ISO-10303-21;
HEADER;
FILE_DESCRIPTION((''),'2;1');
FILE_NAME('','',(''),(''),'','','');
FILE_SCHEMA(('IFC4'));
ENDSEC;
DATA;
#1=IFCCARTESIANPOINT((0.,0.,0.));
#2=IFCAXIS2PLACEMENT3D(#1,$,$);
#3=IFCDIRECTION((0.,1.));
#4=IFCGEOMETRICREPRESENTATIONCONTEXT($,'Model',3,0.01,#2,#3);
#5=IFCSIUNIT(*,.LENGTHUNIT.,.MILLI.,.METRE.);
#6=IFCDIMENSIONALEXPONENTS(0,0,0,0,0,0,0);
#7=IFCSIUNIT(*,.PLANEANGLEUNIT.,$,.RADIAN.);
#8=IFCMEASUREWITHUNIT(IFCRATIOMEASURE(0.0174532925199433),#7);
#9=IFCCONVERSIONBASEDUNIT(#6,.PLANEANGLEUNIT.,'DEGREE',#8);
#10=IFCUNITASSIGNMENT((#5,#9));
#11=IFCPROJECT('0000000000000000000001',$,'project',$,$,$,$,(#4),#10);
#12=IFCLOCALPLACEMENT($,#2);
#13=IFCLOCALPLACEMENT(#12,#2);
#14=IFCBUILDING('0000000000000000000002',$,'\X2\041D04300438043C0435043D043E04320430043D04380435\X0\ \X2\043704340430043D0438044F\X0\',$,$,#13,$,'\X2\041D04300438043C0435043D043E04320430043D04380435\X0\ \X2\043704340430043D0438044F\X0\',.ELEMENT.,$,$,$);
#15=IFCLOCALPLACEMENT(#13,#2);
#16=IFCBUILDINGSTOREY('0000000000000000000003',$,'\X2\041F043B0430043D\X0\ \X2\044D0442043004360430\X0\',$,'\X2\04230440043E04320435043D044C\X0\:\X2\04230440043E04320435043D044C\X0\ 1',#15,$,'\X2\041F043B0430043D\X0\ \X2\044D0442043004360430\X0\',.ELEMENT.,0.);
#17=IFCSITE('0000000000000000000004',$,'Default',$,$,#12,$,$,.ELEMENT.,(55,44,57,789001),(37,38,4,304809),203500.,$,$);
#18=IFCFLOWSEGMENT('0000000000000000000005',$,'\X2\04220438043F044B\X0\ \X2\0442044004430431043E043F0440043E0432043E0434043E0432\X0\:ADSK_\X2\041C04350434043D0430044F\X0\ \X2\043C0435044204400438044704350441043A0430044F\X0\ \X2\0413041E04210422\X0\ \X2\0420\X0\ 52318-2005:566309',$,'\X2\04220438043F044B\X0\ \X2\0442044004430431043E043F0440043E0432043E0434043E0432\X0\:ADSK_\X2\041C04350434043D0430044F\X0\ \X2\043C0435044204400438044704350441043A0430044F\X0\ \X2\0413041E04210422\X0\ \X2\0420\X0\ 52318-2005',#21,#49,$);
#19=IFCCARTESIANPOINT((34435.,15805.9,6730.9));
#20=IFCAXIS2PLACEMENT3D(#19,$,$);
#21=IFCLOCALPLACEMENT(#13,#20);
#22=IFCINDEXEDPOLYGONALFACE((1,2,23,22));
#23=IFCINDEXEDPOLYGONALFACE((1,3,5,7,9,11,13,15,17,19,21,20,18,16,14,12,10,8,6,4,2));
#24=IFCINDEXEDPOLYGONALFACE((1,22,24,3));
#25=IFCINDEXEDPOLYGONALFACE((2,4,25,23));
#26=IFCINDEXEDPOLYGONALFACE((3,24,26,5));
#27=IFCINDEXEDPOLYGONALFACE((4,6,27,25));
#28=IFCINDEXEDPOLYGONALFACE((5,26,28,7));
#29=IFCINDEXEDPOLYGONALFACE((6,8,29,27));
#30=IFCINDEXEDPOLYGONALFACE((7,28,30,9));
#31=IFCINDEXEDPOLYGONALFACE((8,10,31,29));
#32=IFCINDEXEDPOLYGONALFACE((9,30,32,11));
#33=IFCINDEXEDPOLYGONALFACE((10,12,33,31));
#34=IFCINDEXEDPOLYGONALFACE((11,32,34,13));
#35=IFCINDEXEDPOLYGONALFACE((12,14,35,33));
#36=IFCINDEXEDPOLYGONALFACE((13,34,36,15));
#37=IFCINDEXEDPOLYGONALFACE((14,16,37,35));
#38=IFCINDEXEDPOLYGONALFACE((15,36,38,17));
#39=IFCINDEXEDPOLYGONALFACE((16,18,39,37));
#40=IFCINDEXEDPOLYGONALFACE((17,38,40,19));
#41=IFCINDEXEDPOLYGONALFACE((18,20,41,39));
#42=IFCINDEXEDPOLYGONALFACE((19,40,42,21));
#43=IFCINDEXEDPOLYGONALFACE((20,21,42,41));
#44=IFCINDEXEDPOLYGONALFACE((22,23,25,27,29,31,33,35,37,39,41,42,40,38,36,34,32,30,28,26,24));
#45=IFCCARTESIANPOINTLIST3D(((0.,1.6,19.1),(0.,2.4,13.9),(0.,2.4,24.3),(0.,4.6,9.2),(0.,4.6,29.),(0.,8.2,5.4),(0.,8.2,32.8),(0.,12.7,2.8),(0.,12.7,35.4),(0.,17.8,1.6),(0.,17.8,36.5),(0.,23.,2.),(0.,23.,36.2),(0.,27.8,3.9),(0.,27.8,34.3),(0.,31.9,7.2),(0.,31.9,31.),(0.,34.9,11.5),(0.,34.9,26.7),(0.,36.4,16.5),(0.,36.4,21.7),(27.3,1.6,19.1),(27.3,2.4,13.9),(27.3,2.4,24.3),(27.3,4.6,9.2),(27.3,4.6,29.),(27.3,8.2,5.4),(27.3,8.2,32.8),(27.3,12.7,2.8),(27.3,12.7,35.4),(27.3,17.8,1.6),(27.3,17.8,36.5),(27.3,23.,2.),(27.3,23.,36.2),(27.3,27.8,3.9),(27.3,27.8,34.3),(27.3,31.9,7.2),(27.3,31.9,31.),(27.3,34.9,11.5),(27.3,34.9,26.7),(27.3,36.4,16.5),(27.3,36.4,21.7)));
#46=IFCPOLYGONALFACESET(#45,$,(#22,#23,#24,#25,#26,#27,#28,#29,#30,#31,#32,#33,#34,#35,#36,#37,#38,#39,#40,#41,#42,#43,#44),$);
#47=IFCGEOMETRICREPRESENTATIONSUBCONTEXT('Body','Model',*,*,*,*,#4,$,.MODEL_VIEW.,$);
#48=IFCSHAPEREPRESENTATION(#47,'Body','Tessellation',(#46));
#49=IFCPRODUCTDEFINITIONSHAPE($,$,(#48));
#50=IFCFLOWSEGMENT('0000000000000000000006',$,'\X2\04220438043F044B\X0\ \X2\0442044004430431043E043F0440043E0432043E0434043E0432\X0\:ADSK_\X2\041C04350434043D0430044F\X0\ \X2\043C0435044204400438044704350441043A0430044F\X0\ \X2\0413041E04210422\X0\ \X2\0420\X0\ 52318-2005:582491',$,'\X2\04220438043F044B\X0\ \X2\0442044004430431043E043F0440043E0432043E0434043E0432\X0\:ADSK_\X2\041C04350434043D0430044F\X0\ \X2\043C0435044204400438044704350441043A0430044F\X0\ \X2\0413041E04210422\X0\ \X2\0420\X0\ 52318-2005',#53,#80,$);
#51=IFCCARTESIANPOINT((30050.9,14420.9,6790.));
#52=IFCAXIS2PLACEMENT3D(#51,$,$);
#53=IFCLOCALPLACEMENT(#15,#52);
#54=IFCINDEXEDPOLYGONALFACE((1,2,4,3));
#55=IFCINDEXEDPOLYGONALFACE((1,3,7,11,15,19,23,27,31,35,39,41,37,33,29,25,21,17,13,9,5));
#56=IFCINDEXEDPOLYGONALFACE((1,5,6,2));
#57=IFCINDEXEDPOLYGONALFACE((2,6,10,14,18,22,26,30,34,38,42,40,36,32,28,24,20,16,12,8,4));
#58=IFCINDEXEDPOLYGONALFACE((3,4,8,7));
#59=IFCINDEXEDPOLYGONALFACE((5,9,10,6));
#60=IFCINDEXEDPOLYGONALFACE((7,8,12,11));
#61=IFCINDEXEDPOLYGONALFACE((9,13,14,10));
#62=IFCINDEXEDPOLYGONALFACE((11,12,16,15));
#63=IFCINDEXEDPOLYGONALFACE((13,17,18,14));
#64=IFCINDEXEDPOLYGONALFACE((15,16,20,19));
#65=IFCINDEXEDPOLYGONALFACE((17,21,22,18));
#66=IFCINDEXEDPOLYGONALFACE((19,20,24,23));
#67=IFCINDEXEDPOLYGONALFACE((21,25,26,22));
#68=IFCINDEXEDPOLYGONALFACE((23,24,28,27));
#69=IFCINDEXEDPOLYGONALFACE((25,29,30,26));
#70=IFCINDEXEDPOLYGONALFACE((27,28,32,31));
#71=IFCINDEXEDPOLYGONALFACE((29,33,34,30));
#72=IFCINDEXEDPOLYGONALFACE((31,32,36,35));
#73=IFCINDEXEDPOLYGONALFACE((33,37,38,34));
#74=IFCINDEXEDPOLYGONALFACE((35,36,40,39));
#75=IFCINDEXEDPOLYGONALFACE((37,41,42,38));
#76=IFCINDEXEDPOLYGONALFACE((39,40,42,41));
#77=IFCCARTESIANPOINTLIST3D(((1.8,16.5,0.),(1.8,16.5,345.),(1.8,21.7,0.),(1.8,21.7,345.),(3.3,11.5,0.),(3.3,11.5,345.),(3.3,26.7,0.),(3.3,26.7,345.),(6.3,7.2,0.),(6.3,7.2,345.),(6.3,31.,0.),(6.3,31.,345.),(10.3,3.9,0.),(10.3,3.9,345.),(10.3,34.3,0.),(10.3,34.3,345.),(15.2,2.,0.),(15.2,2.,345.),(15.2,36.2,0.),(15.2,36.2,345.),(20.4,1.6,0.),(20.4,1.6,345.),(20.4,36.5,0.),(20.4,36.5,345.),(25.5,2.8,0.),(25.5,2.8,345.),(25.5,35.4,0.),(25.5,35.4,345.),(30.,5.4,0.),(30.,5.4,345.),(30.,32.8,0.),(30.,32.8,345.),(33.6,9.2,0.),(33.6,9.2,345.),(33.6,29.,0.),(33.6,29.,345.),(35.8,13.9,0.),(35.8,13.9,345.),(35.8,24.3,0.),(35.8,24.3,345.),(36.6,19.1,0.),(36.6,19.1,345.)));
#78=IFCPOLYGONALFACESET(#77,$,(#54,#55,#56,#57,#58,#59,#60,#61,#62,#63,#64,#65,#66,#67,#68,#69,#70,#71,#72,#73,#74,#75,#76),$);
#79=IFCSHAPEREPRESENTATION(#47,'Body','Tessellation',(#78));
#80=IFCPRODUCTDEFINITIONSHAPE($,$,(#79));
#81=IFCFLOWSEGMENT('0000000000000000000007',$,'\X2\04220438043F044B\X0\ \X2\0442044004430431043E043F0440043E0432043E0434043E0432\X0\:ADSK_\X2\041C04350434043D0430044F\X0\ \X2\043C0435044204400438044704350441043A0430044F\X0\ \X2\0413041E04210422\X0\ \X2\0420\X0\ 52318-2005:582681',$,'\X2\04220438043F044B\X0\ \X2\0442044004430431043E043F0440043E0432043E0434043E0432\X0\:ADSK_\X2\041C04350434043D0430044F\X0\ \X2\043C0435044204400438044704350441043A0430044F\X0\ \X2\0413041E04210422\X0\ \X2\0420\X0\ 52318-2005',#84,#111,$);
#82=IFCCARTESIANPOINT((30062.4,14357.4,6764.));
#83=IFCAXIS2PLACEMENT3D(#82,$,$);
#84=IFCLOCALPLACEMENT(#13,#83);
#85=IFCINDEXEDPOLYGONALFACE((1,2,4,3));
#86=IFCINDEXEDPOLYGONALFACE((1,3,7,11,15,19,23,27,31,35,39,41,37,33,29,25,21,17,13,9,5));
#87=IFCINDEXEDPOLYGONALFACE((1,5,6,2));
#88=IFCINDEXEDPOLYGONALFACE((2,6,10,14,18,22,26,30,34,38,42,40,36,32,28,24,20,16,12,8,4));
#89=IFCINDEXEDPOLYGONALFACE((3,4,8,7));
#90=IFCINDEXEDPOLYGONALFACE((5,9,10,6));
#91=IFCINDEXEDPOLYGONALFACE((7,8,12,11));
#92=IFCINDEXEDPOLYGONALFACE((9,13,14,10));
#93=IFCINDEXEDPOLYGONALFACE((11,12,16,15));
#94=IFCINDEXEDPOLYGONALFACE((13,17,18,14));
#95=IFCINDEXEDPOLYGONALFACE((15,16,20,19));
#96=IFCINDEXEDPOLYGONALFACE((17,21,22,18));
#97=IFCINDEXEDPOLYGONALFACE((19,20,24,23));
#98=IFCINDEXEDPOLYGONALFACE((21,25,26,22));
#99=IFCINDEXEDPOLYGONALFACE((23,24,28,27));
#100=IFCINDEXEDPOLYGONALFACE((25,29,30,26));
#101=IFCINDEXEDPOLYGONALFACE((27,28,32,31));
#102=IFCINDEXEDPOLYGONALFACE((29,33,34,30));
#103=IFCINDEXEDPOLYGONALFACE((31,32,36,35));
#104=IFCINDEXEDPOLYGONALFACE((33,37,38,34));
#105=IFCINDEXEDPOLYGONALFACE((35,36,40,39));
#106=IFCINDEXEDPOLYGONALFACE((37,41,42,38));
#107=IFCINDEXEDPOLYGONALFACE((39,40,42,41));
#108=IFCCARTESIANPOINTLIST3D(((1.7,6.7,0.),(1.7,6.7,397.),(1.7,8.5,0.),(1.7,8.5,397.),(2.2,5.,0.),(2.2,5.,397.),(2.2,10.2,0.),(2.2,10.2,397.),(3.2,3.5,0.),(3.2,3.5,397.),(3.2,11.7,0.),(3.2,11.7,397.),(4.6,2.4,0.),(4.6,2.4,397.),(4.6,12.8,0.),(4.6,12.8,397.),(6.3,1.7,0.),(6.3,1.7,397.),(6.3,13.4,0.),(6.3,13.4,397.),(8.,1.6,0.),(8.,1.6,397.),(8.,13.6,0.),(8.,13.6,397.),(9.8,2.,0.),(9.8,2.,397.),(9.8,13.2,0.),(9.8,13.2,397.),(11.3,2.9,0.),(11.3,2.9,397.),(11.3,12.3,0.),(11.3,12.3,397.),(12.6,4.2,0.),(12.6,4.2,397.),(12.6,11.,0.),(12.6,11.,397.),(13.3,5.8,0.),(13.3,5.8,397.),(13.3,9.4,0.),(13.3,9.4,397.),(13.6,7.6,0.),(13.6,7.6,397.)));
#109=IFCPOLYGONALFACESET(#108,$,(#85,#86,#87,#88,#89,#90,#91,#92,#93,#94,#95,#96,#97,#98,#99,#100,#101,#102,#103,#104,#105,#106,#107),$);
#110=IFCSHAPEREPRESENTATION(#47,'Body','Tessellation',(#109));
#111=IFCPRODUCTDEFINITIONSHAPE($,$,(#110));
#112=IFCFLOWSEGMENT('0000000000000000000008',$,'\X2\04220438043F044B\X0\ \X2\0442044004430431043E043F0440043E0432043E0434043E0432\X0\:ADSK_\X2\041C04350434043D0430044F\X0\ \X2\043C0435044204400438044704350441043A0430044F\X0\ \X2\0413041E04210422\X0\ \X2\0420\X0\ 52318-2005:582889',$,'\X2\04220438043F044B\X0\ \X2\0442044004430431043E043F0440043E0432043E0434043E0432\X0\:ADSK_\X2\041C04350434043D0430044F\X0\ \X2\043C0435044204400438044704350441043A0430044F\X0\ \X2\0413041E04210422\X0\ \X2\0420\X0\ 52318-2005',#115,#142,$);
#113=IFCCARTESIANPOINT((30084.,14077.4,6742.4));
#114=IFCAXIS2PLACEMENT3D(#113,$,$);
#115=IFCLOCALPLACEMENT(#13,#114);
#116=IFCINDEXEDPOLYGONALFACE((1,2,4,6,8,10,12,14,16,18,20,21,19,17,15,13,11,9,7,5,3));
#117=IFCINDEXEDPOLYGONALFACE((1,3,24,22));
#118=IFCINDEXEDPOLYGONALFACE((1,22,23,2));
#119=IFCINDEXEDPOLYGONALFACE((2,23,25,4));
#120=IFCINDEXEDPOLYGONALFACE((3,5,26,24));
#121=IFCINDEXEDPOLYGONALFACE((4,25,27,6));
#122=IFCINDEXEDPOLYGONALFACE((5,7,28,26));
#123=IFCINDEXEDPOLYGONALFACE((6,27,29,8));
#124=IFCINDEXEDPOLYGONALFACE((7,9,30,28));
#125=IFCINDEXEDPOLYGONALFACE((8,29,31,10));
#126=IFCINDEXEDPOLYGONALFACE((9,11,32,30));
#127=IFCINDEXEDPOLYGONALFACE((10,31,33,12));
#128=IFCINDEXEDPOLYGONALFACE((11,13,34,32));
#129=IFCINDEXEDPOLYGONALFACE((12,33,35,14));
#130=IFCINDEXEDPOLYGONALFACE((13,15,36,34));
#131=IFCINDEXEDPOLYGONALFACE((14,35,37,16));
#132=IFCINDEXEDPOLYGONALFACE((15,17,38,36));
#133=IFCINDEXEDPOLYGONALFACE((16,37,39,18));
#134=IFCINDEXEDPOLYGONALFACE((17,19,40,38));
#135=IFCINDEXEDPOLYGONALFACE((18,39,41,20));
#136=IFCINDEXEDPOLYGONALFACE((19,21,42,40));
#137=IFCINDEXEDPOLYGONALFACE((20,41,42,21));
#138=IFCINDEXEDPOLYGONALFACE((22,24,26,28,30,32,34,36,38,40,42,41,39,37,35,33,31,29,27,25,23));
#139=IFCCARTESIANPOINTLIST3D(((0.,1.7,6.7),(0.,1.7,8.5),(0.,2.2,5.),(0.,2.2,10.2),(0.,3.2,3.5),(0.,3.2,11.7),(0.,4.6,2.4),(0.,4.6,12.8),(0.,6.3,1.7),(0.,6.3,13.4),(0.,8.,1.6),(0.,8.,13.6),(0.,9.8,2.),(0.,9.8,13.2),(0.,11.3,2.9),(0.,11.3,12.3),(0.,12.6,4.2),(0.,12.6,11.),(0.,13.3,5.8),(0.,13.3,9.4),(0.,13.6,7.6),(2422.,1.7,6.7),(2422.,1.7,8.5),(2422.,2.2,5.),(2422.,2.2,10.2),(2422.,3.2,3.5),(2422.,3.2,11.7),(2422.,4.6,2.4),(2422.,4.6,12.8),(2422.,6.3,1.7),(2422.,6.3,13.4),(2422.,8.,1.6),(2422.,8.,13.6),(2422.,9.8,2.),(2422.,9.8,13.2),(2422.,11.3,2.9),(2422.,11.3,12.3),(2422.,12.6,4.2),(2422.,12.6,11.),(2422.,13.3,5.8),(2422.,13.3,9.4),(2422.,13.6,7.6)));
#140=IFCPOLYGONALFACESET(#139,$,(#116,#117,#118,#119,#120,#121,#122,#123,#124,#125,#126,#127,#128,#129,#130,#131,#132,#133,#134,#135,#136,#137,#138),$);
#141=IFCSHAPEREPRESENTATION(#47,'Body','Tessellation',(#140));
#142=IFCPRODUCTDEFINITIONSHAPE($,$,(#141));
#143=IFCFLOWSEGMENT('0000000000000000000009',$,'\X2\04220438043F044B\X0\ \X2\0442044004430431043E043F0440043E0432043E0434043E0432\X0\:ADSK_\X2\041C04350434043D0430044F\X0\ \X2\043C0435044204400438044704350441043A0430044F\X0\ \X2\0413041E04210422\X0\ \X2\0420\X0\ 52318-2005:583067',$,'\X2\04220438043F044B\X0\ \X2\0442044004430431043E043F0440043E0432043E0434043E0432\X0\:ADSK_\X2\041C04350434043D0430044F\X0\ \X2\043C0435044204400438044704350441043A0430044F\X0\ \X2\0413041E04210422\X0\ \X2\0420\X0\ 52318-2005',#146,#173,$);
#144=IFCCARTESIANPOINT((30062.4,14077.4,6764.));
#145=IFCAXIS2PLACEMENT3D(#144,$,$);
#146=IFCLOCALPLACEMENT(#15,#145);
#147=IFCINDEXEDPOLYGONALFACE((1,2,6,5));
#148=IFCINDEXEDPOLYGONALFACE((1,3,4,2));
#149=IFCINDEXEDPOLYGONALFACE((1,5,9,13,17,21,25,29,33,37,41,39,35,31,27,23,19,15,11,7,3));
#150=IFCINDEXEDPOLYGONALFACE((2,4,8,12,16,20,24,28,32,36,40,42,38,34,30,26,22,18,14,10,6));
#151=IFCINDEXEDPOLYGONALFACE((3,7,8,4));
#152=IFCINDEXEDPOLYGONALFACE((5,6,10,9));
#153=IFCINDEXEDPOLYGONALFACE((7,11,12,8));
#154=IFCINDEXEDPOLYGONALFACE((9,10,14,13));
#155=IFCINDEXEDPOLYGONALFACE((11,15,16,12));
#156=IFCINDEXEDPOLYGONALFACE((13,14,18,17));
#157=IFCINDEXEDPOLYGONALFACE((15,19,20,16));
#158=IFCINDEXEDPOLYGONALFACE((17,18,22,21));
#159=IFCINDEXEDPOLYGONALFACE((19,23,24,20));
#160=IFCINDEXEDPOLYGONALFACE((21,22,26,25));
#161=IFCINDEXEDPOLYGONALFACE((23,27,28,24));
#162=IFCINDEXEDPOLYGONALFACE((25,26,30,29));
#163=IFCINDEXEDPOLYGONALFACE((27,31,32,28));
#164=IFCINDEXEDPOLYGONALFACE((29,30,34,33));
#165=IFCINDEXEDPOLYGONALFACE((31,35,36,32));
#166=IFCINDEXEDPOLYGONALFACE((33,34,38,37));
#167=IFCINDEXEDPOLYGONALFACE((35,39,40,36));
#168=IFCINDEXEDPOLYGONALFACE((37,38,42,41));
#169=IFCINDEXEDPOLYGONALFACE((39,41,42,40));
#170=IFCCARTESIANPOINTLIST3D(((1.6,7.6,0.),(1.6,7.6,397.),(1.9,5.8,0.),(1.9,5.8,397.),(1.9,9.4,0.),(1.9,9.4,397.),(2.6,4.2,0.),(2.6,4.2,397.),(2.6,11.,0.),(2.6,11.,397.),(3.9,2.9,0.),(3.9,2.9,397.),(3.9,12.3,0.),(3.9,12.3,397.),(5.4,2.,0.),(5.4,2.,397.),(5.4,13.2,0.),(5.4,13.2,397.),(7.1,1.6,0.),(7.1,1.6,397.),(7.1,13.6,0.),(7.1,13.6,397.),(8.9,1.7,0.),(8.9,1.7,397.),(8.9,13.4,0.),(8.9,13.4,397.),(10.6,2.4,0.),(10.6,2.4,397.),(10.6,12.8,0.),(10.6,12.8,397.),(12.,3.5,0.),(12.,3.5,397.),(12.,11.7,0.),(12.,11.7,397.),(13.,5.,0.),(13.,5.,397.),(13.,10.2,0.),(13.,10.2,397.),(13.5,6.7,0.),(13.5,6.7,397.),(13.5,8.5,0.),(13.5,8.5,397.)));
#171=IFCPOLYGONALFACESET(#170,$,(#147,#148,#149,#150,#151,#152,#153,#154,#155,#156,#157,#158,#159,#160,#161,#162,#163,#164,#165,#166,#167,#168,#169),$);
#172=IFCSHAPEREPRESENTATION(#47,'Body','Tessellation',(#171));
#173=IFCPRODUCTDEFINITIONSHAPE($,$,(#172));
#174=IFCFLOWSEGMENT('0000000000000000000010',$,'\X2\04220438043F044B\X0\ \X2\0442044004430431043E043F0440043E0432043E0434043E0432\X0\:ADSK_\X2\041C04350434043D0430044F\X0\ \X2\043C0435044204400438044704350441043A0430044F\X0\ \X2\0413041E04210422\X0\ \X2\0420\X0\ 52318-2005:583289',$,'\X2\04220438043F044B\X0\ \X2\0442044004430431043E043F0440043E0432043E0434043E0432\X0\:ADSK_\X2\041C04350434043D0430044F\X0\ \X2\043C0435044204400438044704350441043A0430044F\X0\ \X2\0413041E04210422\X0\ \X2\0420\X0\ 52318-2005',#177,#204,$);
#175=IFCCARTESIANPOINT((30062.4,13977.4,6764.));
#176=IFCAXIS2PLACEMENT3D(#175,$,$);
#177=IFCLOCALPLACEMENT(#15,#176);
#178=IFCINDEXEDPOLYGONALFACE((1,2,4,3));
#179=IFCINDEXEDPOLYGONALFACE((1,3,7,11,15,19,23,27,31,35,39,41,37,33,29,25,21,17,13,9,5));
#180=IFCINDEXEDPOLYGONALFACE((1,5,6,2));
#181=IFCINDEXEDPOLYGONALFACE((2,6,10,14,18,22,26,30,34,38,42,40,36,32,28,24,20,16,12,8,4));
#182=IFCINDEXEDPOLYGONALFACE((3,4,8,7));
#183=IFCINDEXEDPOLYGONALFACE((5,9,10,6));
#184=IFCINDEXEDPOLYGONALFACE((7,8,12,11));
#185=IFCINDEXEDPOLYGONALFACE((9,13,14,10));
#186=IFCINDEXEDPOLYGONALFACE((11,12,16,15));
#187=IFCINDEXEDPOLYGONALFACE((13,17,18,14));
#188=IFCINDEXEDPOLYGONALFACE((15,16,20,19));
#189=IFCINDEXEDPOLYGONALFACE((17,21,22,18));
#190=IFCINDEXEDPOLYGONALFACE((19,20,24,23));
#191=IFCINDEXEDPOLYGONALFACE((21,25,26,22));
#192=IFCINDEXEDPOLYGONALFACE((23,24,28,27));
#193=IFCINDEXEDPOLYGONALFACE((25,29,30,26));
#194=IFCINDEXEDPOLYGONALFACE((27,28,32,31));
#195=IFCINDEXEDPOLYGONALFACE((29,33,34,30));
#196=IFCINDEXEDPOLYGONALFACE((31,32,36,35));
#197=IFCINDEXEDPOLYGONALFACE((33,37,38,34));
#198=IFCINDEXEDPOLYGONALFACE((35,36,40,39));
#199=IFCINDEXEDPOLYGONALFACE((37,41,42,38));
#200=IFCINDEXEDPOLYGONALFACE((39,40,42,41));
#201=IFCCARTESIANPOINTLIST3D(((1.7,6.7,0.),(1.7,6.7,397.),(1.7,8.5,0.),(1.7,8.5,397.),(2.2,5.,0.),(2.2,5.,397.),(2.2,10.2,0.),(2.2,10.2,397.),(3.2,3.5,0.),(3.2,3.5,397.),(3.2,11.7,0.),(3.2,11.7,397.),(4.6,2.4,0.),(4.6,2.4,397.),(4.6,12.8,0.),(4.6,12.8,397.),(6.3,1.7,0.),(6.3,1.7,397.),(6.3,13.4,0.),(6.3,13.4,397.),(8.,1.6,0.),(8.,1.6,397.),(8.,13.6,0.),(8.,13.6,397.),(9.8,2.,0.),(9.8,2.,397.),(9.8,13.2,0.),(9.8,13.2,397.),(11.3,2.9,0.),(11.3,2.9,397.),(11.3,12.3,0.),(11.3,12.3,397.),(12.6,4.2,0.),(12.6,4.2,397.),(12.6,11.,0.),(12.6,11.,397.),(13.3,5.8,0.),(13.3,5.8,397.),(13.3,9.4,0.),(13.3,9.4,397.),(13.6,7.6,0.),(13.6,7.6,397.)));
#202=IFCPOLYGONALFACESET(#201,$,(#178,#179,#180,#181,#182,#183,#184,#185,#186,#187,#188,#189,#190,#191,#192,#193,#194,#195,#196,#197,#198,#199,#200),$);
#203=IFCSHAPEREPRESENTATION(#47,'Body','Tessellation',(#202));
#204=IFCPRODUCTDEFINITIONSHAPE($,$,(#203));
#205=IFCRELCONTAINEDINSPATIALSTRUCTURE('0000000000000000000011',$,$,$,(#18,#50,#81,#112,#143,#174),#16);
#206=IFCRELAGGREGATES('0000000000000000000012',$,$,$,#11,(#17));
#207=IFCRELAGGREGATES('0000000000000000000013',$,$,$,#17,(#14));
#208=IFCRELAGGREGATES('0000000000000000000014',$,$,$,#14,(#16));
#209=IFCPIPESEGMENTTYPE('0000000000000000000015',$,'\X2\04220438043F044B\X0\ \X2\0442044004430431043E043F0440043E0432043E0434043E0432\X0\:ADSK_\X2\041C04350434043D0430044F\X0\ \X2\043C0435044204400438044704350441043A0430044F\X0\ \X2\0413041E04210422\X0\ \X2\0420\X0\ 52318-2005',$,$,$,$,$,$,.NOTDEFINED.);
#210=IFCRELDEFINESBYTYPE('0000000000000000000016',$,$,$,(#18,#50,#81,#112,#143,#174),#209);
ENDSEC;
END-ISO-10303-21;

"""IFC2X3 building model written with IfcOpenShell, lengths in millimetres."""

from ifc_helpers import new_model, entity, si_unit, converted_unit, direction, frame, frame_2d, origin, origin_2d_with_axis, place, context, subcontext, project, spatial, circle, extrude, type_object, element, save


model = new_model("IFC2X3")

# Units and contexts
model_context = context("Model", 3, precision=0.01, world=origin(), true_north=direction((0.0, 1.0)))
body_context = subcontext(model_context, "Body", "Model", "MODEL_VIEW")
ifc_project = project(units=[si_unit("LENGTHUNIT", "METRE", prefix="MILLI"), converted_unit("PLANEANGLEUNIT", "DEGREE", entity("IfcRatioMeasure", 0.0174532925199433), si_unit("PLANEANGLEUNIT", "RADIAN"), dimensions=[0, 0, 0, 0, 0, 0, 0])], contexts=[model_context])

# Site, building, storey
site_placement = place(None, frame((0.0, 0.0, 0.0)))
site = spatial("IfcSite", under=ifc_project, at=site_placement, Name="Default", CompositionType="ELEMENT", RefLatitude=(55, 44, 57, 789001), RefLongitude=(37, 38, 4, 304809), RefElevation=203500.0)
building_placement = place(site_placement, origin())
building = spatial("IfcBuilding", under=site, at=building_placement, Name="Наименование здания", LongName="Наименование здания", CompositionType="ELEMENT")
storey_placement = place(building_placement, origin())
storey = spatial("IfcBuildingStorey", under=building, at=storey_placement, Name="План этажа", ObjectType="Уровень:Уровень 1", LongName="План этажа", CompositionType="ELEMENT", Elevation=0.0)

# Flow segments
pipe_segment_type = type_object("IfcPipeSegmentType", Name="Типы трубопроводов:ADSK_Медная метрическая ГОСТ Р 52318-2005", PredefinedType="NOTDEFINED")
flow_segment_1_placement = place(building_placement, frame((34435.0, 15805.9, 6730.9)))
element("IfcFlowSegment", 1, at=flow_segment_1_placement, inside=storey, type_object=pipe_segment_type, Name="Типы трубопроводов:ADSK_Медная метрическая ГОСТ Р 52318-2005:566309", ObjectType="Типы трубопроводов:ADSK_Медная метрическая ГОСТ Р 52318-2005", context=body_context, shape_type="SweptSolid", body=[
    extrude(circle(Radius=17.5, at=origin_2d_with_axis()), frame((0.0, 19.1, 19.1), z_axis=(1.0, 0.0, 0.0), x_axis=(0.0, -1.0, 0.0)), (0.0, 0.0, 1.0), 27.3),
])
flow_segment_2_placement = place(storey_placement, frame((30050.9, 14420.9, 6790.0)))
element("IfcFlowSegment", 2, at=flow_segment_2_placement, inside=storey, type_object=pipe_segment_type, Name="Типы трубопроводов:ADSK_Медная метрическая ГОСТ Р 52318-2005:582491", ObjectType="Типы трубопроводов:ADSK_Медная метрическая ГОСТ Р 52318-2005", context=body_context, shape_type="SweptSolid", body=[
    extrude(circle(Radius=17.5, at=origin_2d_with_axis()), frame((19.1, 19.1, 0.0)), (0.0, 0.0, 1.0), 345.0),
])
flow_segment_3_placement = place(building_placement, frame((30062.4, 14357.4, 6764.0)))
element("IfcFlowSegment", 3, at=flow_segment_3_placement, inside=storey, type_object=pipe_segment_type, Name="Типы трубопроводов:ADSK_Медная метрическая ГОСТ Р 52318-2005:582681", ObjectType="Типы трубопроводов:ADSK_Медная метрическая ГОСТ Р 52318-2005", context=body_context, shape_type="SweptSolid", body=[
    extrude(circle(Radius=6.0, at=frame_2d((0.0, 0.0), x_axis=(1.0, 0.0))), frame((7.6, 7.6, 0.0)), (0.0, 0.0, 1.0), 397.0),
])
flow_segment_4_placement = place(building_placement, frame((30084.0, 14077.4, 6742.4)))
element("IfcFlowSegment", 4, at=flow_segment_4_placement, inside=storey, type_object=pipe_segment_type, Name="Типы трубопроводов:ADSK_Медная метрическая ГОСТ Р 52318-2005:582889", ObjectType="Типы трубопроводов:ADSK_Медная метрическая ГОСТ Р 52318-2005", context=body_context, shape_type="SweptSolid", body=[
    extrude(circle(Radius=6.0, at=origin_2d_with_axis()), frame((0.0, 7.6, 7.6), z_axis=(1.0, 0.0, 0.0), x_axis=(0.0, 1.0, 0.0)), (0.0, 0.0, 1.0), 2422.0),
])
flow_segment_5_placement = place(storey_placement, frame((30062.4, 14077.4, 6764.0)))
element("IfcFlowSegment", 5, at=flow_segment_5_placement, inside=storey, type_object=pipe_segment_type, Name="Типы трубопроводов:ADSK_Медная метрическая ГОСТ Р 52318-2005:583067", ObjectType="Типы трубопроводов:ADSK_Медная метрическая ГОСТ Р 52318-2005", context=body_context, shape_type="SweptSolid", body=[
    extrude(circle(Radius=6.0, at=origin_2d_with_axis()), frame((7.6, 7.6, 0.0), z_axis=(0.0, 0.0, 1.0), x_axis=(-1.0, 0.0, 0.0)), (0.0, 0.0, 1.0), 397.0),
])
flow_segment_6_placement = place(storey_placement, frame((30062.4, 13977.4, 6764.0)))
element("IfcFlowSegment", 6, at=flow_segment_6_placement, inside=storey, type_object=pipe_segment_type, Name="Типы трубопроводов:ADSK_Медная метрическая ГОСТ Р 52318-2005:583289", ObjectType="Типы трубопроводов:ADSK_Медная метрическая ГОСТ Р 52318-2005", context=body_context, shape_type="SweptSolid", body=[
    extrude(circle(Radius=6.0, at=origin_2d_with_axis()), frame((7.6, 7.6, 0.0)), (0.0, 0.0, 1.0), 397.0),
])

save(model, "model.ifc")
